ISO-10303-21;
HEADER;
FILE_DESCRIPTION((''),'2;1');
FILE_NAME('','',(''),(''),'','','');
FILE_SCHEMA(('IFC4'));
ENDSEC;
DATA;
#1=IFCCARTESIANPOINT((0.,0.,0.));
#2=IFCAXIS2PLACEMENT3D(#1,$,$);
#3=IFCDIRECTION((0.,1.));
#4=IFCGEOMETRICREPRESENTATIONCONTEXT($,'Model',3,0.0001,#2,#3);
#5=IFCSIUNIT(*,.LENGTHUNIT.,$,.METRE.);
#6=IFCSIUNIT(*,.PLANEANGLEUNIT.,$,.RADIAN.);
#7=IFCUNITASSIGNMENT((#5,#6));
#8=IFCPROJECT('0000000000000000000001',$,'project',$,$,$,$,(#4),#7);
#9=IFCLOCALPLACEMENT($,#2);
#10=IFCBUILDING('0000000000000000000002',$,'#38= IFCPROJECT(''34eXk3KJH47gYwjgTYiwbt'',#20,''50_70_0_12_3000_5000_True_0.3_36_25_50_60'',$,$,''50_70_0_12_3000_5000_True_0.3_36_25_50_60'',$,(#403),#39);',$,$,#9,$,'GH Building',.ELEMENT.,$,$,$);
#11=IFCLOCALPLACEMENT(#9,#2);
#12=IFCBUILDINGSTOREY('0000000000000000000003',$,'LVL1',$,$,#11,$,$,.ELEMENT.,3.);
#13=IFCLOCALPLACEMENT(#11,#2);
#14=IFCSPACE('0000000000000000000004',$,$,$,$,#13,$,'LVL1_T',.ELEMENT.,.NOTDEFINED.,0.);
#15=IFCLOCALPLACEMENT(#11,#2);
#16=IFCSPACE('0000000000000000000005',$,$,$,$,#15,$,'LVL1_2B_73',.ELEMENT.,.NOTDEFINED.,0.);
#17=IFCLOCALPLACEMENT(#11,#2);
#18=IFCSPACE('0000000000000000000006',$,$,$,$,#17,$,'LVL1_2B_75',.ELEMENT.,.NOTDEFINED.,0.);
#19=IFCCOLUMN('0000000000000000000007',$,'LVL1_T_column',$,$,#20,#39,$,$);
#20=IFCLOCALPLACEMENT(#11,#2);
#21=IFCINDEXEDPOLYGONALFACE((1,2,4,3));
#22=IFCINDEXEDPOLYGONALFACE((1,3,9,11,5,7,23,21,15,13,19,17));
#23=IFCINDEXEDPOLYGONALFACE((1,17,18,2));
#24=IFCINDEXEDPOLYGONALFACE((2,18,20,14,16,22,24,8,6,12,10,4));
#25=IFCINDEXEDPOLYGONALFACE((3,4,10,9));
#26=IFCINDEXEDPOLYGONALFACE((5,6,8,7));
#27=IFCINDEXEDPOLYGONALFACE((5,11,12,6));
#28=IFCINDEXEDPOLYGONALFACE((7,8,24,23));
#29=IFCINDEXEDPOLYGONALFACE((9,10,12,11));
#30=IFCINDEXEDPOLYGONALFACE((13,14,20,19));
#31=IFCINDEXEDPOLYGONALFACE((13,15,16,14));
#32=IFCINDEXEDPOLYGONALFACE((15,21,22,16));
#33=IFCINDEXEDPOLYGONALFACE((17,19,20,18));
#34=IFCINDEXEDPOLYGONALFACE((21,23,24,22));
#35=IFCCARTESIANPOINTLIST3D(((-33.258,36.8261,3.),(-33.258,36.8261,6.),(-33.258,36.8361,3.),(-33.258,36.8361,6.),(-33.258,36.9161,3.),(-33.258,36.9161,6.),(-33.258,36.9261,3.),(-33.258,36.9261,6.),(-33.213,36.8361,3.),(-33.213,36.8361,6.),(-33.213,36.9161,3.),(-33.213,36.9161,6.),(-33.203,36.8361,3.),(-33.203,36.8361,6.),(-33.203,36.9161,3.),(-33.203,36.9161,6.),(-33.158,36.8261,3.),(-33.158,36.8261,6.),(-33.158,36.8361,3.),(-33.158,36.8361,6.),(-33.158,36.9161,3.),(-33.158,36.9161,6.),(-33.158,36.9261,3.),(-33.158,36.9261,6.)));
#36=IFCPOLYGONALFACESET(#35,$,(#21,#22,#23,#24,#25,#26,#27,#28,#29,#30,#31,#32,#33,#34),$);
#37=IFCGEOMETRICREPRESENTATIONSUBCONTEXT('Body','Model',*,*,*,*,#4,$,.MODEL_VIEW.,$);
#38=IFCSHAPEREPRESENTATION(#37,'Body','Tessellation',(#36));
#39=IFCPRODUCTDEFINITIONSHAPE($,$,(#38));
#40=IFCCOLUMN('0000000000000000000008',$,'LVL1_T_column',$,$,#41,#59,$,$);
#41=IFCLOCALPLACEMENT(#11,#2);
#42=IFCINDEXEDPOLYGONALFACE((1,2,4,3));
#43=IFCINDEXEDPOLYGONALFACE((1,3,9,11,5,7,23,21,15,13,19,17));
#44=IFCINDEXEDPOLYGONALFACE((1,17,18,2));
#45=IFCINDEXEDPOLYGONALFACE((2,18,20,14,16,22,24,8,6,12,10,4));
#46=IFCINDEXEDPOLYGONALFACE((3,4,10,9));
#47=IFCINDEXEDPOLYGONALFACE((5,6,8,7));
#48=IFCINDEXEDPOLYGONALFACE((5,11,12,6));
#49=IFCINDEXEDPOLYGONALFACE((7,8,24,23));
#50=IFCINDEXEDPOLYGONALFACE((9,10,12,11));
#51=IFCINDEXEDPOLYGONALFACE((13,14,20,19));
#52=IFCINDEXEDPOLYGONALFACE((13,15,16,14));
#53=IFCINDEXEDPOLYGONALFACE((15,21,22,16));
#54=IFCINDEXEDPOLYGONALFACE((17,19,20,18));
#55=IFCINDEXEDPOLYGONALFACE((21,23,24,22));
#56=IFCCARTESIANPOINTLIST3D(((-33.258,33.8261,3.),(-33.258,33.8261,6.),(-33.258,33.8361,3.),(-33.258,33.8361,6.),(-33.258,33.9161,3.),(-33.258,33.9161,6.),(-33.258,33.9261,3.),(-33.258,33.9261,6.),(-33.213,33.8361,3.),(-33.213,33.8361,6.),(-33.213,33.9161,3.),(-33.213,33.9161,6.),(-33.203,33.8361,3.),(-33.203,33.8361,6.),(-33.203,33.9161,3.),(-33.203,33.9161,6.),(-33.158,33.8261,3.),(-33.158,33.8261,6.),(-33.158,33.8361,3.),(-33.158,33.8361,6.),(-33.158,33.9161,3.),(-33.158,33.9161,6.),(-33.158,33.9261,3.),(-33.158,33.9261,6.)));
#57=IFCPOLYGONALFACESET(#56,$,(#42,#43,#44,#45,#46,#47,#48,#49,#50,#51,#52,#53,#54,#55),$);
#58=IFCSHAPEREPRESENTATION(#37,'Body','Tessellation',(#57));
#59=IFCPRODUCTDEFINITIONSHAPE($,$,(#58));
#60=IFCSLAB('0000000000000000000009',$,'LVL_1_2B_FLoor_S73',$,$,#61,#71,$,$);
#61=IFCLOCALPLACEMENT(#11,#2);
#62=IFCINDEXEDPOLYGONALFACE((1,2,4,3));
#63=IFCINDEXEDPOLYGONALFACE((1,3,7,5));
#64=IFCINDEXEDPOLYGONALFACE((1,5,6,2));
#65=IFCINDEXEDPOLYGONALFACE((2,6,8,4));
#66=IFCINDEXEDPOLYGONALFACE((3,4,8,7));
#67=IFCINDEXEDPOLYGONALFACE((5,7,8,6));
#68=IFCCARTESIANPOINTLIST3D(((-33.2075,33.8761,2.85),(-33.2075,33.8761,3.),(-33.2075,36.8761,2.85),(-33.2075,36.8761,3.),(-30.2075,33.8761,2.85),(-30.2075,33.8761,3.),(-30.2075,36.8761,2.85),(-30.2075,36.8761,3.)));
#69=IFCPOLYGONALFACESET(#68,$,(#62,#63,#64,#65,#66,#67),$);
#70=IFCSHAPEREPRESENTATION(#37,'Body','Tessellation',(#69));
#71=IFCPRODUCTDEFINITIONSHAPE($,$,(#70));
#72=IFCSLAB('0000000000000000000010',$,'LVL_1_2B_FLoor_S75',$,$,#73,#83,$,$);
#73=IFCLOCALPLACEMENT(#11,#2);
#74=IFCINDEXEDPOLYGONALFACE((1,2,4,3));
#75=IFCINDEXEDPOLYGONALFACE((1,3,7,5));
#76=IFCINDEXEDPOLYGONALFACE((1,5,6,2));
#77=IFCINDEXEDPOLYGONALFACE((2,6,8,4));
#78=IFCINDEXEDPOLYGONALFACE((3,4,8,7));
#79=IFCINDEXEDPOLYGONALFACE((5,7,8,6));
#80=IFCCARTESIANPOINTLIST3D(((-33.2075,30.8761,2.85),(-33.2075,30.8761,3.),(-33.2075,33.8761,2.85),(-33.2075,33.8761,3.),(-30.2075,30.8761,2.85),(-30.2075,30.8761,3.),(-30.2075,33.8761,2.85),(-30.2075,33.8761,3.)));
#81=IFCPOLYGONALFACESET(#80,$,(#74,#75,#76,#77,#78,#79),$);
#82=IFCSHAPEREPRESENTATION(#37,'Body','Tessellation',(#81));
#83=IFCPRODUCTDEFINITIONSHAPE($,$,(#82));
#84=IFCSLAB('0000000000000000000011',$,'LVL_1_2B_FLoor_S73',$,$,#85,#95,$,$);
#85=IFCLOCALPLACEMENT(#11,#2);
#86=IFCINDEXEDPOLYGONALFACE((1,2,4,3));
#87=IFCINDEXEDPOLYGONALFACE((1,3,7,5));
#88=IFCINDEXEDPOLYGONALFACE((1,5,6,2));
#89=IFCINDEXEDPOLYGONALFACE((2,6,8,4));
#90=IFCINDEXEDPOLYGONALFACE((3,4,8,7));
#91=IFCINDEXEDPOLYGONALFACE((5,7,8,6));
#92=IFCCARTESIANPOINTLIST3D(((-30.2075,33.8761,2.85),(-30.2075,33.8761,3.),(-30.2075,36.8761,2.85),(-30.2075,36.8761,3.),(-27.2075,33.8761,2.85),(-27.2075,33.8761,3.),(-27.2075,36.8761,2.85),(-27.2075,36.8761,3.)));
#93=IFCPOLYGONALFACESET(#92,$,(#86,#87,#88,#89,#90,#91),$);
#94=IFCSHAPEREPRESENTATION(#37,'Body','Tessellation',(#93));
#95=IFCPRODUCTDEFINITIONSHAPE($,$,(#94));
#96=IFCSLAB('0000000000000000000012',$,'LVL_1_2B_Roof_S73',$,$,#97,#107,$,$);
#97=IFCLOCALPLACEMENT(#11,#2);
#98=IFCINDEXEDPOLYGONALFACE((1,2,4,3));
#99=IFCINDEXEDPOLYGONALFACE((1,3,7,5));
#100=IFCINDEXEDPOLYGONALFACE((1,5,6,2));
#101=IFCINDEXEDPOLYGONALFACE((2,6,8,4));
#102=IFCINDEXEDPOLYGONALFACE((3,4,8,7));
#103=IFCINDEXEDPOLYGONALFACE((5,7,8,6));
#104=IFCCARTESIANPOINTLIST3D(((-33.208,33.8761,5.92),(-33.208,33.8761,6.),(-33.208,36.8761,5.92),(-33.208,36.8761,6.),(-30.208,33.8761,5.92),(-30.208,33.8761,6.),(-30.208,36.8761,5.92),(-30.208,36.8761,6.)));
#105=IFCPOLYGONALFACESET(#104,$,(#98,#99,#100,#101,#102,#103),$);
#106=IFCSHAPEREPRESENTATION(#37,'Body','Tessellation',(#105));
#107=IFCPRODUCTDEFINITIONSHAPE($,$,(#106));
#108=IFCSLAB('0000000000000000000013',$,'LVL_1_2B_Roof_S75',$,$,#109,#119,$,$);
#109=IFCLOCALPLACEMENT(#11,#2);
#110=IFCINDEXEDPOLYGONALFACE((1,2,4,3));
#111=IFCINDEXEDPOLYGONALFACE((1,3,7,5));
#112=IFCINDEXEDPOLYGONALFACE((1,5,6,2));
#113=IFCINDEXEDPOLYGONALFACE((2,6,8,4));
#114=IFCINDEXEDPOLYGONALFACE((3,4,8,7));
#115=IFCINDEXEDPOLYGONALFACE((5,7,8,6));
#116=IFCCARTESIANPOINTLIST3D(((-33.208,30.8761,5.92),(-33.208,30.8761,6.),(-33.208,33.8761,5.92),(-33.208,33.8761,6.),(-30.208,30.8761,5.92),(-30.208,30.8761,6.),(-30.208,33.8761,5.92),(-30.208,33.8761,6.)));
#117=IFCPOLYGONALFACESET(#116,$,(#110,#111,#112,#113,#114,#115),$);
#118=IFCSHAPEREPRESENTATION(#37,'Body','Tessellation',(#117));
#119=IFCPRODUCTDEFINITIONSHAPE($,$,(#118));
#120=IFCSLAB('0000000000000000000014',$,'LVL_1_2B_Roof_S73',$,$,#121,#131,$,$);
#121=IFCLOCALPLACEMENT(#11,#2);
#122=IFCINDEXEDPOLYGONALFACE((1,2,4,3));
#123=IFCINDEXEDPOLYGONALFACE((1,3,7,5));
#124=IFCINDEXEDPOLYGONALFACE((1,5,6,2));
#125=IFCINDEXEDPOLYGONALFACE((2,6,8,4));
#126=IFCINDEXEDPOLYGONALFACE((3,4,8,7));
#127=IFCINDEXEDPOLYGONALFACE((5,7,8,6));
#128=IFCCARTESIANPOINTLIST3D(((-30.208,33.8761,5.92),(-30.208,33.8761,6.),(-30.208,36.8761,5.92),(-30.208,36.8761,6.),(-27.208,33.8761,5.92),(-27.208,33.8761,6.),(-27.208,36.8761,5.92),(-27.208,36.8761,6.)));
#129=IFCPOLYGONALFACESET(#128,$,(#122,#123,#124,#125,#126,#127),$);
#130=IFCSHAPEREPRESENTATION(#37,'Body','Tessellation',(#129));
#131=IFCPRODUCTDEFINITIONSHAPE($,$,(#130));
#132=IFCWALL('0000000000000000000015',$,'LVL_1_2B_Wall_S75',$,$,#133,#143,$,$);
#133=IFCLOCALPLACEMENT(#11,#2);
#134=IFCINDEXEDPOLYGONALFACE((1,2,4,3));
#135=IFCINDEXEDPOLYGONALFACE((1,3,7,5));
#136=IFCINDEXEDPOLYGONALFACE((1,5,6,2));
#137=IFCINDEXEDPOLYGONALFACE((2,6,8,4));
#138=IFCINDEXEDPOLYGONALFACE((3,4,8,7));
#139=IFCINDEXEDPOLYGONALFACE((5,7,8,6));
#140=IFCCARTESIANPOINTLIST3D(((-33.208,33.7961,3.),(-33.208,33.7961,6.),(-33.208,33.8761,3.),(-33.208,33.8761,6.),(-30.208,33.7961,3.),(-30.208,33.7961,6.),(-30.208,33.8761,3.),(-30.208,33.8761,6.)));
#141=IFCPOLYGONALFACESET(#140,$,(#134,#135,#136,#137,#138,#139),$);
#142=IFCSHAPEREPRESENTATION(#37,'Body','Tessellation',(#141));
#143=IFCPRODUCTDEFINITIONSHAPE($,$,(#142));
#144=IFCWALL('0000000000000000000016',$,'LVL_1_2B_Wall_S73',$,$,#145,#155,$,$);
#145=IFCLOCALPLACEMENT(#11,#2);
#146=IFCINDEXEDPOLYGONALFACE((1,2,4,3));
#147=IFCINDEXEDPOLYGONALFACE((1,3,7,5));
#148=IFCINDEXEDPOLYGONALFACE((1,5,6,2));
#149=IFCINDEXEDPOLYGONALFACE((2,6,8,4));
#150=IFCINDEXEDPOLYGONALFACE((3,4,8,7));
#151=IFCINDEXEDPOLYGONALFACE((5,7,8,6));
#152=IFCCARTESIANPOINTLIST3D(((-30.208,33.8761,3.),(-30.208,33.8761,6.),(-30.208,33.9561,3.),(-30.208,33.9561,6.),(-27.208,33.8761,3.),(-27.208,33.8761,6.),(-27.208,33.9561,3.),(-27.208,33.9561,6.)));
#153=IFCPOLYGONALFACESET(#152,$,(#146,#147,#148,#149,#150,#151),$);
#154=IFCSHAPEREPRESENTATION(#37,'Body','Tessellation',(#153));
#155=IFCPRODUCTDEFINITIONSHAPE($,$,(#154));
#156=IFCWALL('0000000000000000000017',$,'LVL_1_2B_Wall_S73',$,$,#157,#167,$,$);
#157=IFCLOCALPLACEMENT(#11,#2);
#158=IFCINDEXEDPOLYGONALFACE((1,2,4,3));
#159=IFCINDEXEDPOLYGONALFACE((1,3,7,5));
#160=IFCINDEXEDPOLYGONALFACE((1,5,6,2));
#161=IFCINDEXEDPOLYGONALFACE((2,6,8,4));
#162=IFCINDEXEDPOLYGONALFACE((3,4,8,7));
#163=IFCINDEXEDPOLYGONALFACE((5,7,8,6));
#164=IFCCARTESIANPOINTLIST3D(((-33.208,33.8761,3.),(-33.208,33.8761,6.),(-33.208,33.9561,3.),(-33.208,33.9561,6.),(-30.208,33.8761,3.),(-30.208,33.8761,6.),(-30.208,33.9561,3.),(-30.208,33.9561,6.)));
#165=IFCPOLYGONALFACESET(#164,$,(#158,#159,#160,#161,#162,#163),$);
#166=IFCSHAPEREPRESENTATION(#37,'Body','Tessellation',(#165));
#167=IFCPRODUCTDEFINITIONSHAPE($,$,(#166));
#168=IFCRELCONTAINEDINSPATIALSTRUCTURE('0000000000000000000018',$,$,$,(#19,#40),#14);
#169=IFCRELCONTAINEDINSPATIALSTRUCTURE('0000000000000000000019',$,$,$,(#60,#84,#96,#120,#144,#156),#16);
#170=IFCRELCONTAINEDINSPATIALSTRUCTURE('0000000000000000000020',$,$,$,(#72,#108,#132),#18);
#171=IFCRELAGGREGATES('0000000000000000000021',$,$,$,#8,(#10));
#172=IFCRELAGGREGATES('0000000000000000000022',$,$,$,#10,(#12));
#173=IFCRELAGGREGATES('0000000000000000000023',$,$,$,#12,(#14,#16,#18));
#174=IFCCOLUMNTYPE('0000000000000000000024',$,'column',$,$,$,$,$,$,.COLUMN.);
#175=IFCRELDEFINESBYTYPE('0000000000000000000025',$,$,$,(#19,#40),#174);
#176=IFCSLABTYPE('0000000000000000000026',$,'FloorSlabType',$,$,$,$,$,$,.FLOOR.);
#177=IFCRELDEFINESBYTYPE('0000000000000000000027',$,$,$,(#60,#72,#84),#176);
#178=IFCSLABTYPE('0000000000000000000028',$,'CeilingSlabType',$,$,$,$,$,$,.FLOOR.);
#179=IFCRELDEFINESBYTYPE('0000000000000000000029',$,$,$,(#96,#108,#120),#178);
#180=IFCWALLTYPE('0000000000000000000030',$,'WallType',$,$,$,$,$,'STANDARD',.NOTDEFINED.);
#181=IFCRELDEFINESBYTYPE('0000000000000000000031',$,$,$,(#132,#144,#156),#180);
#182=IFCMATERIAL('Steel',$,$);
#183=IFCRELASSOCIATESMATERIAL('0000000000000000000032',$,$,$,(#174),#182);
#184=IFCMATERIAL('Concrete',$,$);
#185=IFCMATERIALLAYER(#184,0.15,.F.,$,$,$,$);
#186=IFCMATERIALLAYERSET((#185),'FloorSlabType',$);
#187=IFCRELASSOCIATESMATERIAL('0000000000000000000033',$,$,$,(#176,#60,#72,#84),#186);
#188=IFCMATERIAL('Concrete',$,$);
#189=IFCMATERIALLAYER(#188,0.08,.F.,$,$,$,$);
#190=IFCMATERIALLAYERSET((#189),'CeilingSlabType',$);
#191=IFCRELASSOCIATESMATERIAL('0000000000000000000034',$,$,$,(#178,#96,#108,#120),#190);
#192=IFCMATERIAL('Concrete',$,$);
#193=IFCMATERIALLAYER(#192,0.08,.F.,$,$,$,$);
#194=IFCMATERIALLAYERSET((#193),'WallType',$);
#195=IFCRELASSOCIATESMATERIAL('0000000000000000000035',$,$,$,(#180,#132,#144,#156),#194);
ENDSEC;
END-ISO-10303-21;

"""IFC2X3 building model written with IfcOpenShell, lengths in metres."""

from ifc_helpers import new_model, si_unit, direction, frame, frame_2d, origin, origin_2d, place, context, subcontext, project, spatial, rectangle, i_section, extrude, material, layer, layer_set, layer_usage, type_object, element, save


model = new_model("IFC2X3")

# Units and contexts
model_context = context("Model", 3, precision=0.0001, world=origin(), true_north=direction((0.0, 1.0)))
body_context = subcontext(model_context, "Body", "Model", "MODEL_VIEW")
ifc_project = project(units=[si_unit("LENGTHUNIT", "METRE"), si_unit("PLANEANGLEUNIT", "RADIAN")], contexts=[model_context])

# Building, storey, space
building_placement = place(None, origin())
building = spatial("IfcBuilding", under=ifc_project, at=building_placement, Name="#38= IFCPROJECT('34eXk3KJH47gYwjgTYiwbt',#20,'50_70_0_12_3000_5000_True_0.3_36_25_50_60',$,$,'50_70_0_12_3000_5000_True_0.3_36_25_50_60',$,(#403),#39);", LongName="GH Building", CompositionType="ELEMENT")
storey_placement = place(building_placement, origin())
storey = spatial("IfcBuildingStorey", under=building, at=storey_placement, Name="LVL1", CompositionType="ELEMENT", Elevation=3.0)
space_1_placement = place(storey_placement, origin())
space_1 = spatial("IfcSpace", under=storey, at=space_1_placement, LongName="LVL1_T", CompositionType="ELEMENT", InteriorOrExteriorSpace="NOTDEFINED", ElevationWithFlooring=0.0)

# Columns
ifc_material_1 = material(Name="Steel")
column_type = type_object("IfcColumnType", Name="column", PredefinedType="COLUMN", material=ifc_material_1)
for number, where, name in (
    (1, (-33.208, 36.8761, 3.0), "LVL1_T_column"),
    (2, (-33.208, 33.8761, 3.0), "LVL1_T_column"),
):
    element("IfcColumn", number, at=place(space_1_placement, frame(where)), inside=space_1, type_object=column_type, Name=name, context=body_context, shape_type="SweptSolid", body=[
        extrude(i_section(OverallWidth=0.1, OverallDepth=0.1, WebThickness=0.01, FlangeThickness=0.01, at=origin_2d()), origin(), (0.0, 0.0, 1.0), 3.0),
    ])

# Shared definitions
space_2_placement = place(storey_placement, origin())
space_2 = spatial("IfcSpace", under=storey, at=space_2_placement, LongName="LVL1_2B_73", CompositionType="ELEMENT", InteriorOrExteriorSpace="NOTDEFINED", ElevationWithFlooring=0.0)

# Slab
ifc_material_2 = material(Name="Concrete")
ifc_layer_1 = layer(ifc_material_2, 0.15, ventilated=False)
ifc_layer_set_1 = layer_set([ifc_layer_1], Name="FloorSlabType")
ifc_layer_usage_1 = layer_usage(ifc_layer_set_1, "AXIS3", "NEGATIVE", -0.15)
slab_type_1 = type_object("IfcSlabType", Name="FloorSlabType", PredefinedType="FLOOR", material=ifc_layer_set_1)
slab_1_placement = place(space_2_placement, frame((-30.2075, 33.8761, 2.85), z_axis=(0.0, 0.0, 1.0), x_axis=(0.0, 1.0, 0.0)))
element("IfcSlab", 3, at=slab_1_placement, inside=space_2, type_object=slab_type_1, material=ifc_layer_usage_1, Name="LVL_1_2B_FLoor_S73", context=body_context, shape_type="SweptSolid", body=[
    extrude(rectangle(XDim=3.0, YDim=3.0, at=frame_2d((1.5, 1.5))), origin(), (0.0, 0.0, 1.0), 0.15),
])

# Shared definitions
space_3_placement = place(storey_placement, origin())
space_3 = spatial("IfcSpace", under=storey, at=space_3_placement, LongName="LVL1_2B_75", CompositionType="ELEMENT", InteriorOrExteriorSpace="NOTDEFINED", ElevationWithFlooring=0.0)

# Slabs
ifc_layer_usage_2 = layer_usage(ifc_layer_set_1, "AXIS3", "NEGATIVE", -0.15)
slab_2_placement = place(space_3_placement, frame((-30.2075, 30.8761, 2.85), z_axis=(0.0, 0.0, 1.0), x_axis=(0.0, 1.0, 0.0)))
element("IfcSlab", 4, at=slab_2_placement, inside=space_3, type_object=slab_type_1, material=ifc_layer_usage_2, Name="LVL_1_2B_FLoor_S75", context=body_context, shape_type="SweptSolid", body=[
    extrude(rectangle(XDim=3.0, YDim=3.0, at=frame_2d((1.5, 1.5))), origin(), (0.0, 0.0, 1.0), 0.15),
])
ifc_layer_usage_3 = layer_usage(ifc_layer_set_1, "AXIS3", "NEGATIVE", -0.15)
slab_3_placement = place(space_2_placement, frame((-27.2075, 33.8761, 2.85), z_axis=(0.0, 0.0, 1.0), x_axis=(0.0, 1.0, 0.0)))
element("IfcSlab", 5, at=slab_3_placement, inside=space_2, type_object=slab_type_1, material=ifc_layer_usage_3, Name="LVL_1_2B_FLoor_S73", context=body_context, shape_type="SweptSolid", body=[
    extrude(rectangle(XDim=3.0, YDim=3.0, at=frame_2d((1.5, 1.5))), origin(), (0.0, 0.0, 1.0), 0.15),
])
ifc_material_3 = material(Name="Concrete")
ifc_layer_2 = layer(ifc_material_3, 0.08, ventilated=False)
ifc_layer_set_2 = layer_set([ifc_layer_2], Name="CeilingSlabType")
ifc_layer_usage_4 = layer_usage(ifc_layer_set_2, "AXIS3", "NEGATIVE", -0.08)
slab_type_2 = type_object("IfcSlabType", Name="CeilingSlabType", PredefinedType="FLOOR", material=ifc_layer_set_2)
slab_4_placement = place(space_2_placement, frame((-30.208, 33.8761, 5.92), z_axis=(0.0, 0.0, 1.0), x_axis=(0.0, 1.0, 0.0)))
element("IfcSlab", 6, at=slab_4_placement, inside=space_2, type_object=slab_type_2, material=ifc_layer_usage_4, Name="LVL_1_2B_Roof_S73", context=body_context, shape_type="SweptSolid", body=[
    extrude(rectangle(XDim=3.0, YDim=3.0, at=frame_2d((1.5, 1.5))), origin(), (0.0, 0.0, 1.0), 0.08),
])
ifc_layer_usage_5 = layer_usage(ifc_layer_set_2, "AXIS3", "NEGATIVE", -0.08)
slab_5_placement = place(space_3_placement, frame((-30.208, 30.8761, 5.92), z_axis=(0.0, 0.0, 1.0), x_axis=(0.0, 1.0, 0.0)))
element("IfcSlab", 7, at=slab_5_placement, inside=space_3, type_object=slab_type_2, material=ifc_layer_usage_5, Name="LVL_1_2B_Roof_S75", context=body_context, shape_type="SweptSolid", body=[
    extrude(rectangle(XDim=3.0, YDim=3.0, at=frame_2d((1.5, 1.5))), origin(), (0.0, 0.0, 1.0), 0.08),
])
ifc_layer_usage_6 = layer_usage(ifc_layer_set_2, "AXIS3", "NEGATIVE", -0.08)
slab_6_placement = place(space_2_placement, frame((-27.208, 33.8761, 5.92), z_axis=(0.0, 0.0, 1.0), x_axis=(0.0, 1.0, 0.0)))
element("IfcSlab", 8, at=slab_6_placement, inside=space_2, type_object=slab_type_2, material=ifc_layer_usage_6, Name="LVL_1_2B_Roof_S73", context=body_context, shape_type="SweptSolid", body=[
    extrude(rectangle(XDim=3.0, YDim=3.0, at=frame_2d((1.5, 1.5))), origin(), (0.0, 0.0, 1.0), 0.08),
])

# Shared definitions
ifc_material_4 = material(Name="Concrete")
ifc_layer_3 = layer(ifc_material_4, 0.08, ventilated=False)
ifc_layer_set_3 = layer_set([ifc_layer_3], Name="WallType")
wall_type = type_object("IfcWallType", Name="WallType", ElementType="STANDARD", PredefinedType="NOTDEFINED", material=ifc_layer_set_3)

# Walls
ifc_layer_usage_7 = layer_usage(ifc_layer_set_3, "AXIS2", "NEGATIVE", 0.0)
wall_1_placement = place(space_3_placement, frame((-33.208, 33.8761, 3.0)))
element("IfcWall", 9, at=wall_1_placement, inside=space_3, type_object=wall_type, material=ifc_layer_usage_7, Name="LVL_1_2B_Wall_S75", context=body_context, shape_type="SweptSolid", body=[
    extrude(rectangle(XDim=3.0, YDim=0.08, at=frame_2d((1.5, -0.04))), origin(), (0.0, 0.0, 1.0), 3.0),
])
ifc_layer_usage_8 = layer_usage(ifc_layer_set_3, "AXIS2", "NEGATIVE", 0.0)
wall_2_placement = place(space_2_placement, frame((-27.208, 33.8761, 3.0), z_axis=(0.0, 0.0, 1.0), x_axis=(-1.0, 0.0, 0.0)))
element("IfcWall", 10, at=wall_2_placement, inside=space_2, type_object=wall_type, material=ifc_layer_usage_8, Name="LVL_1_2B_Wall_S73", context=body_context, shape_type="SweptSolid", body=[
    extrude(rectangle(XDim=3.0, YDim=0.08, at=frame_2d((1.5, -0.04))), origin(), (0.0, 0.0, 1.0), 3.0),
])
ifc_layer_usage_9 = layer_usage(ifc_layer_set_3, "AXIS2", "NEGATIVE", 0.0)
wall_3_placement = place(space_2_placement, frame((-30.208, 33.8761, 3.0), z_axis=(0.0, 0.0, 1.0), x_axis=(-1.0, 0.0, 0.0)))
element("IfcWall", 11, at=wall_3_placement, inside=space_2, type_object=wall_type, material=ifc_layer_usage_9, Name="LVL_1_2B_Wall_S73", context=body_context, shape_type="SweptSolid", body=[
    extrude(rectangle(XDim=3.0, YDim=0.08, at=frame_2d((1.5, -0.04))), origin(), (0.0, 0.0, 1.0), 3.0),
])

save(model, "model.ifc")
